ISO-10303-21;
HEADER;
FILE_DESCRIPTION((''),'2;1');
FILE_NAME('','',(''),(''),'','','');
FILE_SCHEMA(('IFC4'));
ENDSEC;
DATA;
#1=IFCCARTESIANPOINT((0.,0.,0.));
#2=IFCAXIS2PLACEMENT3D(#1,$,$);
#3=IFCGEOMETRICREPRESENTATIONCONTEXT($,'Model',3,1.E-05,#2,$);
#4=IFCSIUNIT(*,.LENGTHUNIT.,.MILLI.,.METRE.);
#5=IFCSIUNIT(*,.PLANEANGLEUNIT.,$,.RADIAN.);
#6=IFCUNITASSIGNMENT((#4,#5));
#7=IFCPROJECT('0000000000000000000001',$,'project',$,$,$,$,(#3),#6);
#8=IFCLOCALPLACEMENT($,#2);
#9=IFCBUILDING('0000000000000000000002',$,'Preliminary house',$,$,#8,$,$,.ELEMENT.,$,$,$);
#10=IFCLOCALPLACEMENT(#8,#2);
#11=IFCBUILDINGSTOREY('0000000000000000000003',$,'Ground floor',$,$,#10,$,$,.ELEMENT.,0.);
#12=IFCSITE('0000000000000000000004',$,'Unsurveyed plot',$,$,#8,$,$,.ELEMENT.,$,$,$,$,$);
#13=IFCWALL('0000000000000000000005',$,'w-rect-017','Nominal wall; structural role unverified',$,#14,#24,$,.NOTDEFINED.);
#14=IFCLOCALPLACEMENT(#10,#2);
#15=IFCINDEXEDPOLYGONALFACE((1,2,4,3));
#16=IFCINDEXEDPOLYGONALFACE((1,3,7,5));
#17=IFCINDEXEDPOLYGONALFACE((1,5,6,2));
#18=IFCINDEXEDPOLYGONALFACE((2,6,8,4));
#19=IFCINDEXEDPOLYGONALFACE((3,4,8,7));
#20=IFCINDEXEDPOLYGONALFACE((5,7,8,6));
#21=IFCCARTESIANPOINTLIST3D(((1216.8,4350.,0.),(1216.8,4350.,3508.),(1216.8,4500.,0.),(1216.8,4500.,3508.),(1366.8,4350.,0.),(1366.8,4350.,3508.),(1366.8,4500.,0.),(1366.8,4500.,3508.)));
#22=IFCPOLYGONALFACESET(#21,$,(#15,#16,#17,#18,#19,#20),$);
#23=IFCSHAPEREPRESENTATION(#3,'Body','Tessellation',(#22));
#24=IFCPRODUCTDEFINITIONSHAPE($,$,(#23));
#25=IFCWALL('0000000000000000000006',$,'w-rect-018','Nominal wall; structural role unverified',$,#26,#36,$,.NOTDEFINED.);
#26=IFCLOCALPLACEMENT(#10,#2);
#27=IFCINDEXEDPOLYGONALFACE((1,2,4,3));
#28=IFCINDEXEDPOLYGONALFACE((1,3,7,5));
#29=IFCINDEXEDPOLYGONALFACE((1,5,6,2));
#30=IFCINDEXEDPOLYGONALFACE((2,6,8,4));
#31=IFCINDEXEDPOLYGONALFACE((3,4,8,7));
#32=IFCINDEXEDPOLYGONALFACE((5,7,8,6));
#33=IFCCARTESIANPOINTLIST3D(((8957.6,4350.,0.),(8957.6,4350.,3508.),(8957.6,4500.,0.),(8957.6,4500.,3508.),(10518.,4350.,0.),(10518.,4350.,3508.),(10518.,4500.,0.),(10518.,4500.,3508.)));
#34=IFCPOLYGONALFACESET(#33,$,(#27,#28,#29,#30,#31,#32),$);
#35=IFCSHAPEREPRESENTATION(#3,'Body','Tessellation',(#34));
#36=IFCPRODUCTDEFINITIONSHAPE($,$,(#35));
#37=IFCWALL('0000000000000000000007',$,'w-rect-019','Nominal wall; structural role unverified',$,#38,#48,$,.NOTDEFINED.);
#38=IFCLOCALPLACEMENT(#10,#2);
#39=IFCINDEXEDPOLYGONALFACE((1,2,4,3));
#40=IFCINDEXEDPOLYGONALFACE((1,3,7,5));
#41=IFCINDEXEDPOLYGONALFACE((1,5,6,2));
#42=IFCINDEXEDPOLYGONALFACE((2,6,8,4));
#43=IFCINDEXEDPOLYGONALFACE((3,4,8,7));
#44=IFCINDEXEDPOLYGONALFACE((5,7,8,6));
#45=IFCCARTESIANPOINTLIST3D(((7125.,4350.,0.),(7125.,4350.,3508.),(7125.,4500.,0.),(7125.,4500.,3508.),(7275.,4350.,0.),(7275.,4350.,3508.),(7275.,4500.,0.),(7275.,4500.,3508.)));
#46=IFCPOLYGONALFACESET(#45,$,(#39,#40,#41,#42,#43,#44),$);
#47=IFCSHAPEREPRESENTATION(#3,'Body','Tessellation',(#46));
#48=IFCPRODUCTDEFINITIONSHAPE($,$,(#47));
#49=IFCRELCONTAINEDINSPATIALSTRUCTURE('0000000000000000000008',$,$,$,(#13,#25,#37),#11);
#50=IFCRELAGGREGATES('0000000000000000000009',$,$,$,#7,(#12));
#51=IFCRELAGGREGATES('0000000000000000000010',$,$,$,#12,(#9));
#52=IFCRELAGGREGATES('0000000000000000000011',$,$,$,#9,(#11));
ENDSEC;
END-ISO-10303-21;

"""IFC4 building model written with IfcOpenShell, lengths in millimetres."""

from ifc_helpers import new_model, si_unit, origin, place, context, project, spatial, polyline, outline, extrude, element, save


model = new_model("IFC4")

# Units and contexts
model_context = context("Model", 3, precision=1e-05, world=origin())
ifc_project = project(units=[si_unit("LENGTHUNIT", "METRE", prefix="MILLI"), si_unit("PLANEANGLEUNIT", "RADIAN")], contexts=[model_context])

# Site, building, storey
placement_1 = place(None, origin())
site = spatial("IfcSite", under=ifc_project, at=placement_1, Name="Unsurveyed plot", CompositionType="ELEMENT")
building = spatial("IfcBuilding", under=site, at=placement_1, Name="Preliminary house", CompositionType="ELEMENT")
placement_2 = place(placement_1, origin())
storey = spatial("IfcBuildingStorey", under=building, at=placement_2, Name="Ground floor", CompositionType="ELEMENT", Elevation=0.0)

# Walls
element("IfcWall", 1, at=placement_2, inside=storey, Name="w-rect-017", Description="Nominal wall; structural role unverified", PredefinedType="NOTDEFINED", context=model_context, shape_type="SweptSolid", body=[
    extrude(outline(polyline([(1216.8, 4350.0), (1366.8, 4350.0), (1366.8, 4500.0), (1216.8, 4500.0), (1216.8, 4350.0)])), origin(), (0.0, 0.0, 1.0), 3508.0),
])
element("IfcWall", 2, at=placement_2, inside=storey, Name="w-rect-018", Description="Nominal wall; structural role unverified", PredefinedType="NOTDEFINED", context=model_context, shape_type="SweptSolid", body=[
    extrude(outline(polyline([(8957.6, 4350.0), (10518.0, 4350.0), (10518.0, 4500.0), (8957.6, 4500.0), (8957.6, 4350.0)])), origin(), (0.0, 0.0, 1.0), 3508.0),
])
element("IfcWall", 3, at=placement_2, inside=storey, Name="w-rect-019", Description="Nominal wall; structural role unverified", PredefinedType="NOTDEFINED", context=model_context, shape_type="SweptSolid", body=[
    extrude(outline(polyline([(7125.0, 4350.0), (7275.0, 4350.0), (7275.0, 4500.0), (7125.0, 4500.0), (7125.0, 4350.0)])), origin(), (0.0, 0.0, 1.0), 3508.0),
])

save(model, "model.ifc")
